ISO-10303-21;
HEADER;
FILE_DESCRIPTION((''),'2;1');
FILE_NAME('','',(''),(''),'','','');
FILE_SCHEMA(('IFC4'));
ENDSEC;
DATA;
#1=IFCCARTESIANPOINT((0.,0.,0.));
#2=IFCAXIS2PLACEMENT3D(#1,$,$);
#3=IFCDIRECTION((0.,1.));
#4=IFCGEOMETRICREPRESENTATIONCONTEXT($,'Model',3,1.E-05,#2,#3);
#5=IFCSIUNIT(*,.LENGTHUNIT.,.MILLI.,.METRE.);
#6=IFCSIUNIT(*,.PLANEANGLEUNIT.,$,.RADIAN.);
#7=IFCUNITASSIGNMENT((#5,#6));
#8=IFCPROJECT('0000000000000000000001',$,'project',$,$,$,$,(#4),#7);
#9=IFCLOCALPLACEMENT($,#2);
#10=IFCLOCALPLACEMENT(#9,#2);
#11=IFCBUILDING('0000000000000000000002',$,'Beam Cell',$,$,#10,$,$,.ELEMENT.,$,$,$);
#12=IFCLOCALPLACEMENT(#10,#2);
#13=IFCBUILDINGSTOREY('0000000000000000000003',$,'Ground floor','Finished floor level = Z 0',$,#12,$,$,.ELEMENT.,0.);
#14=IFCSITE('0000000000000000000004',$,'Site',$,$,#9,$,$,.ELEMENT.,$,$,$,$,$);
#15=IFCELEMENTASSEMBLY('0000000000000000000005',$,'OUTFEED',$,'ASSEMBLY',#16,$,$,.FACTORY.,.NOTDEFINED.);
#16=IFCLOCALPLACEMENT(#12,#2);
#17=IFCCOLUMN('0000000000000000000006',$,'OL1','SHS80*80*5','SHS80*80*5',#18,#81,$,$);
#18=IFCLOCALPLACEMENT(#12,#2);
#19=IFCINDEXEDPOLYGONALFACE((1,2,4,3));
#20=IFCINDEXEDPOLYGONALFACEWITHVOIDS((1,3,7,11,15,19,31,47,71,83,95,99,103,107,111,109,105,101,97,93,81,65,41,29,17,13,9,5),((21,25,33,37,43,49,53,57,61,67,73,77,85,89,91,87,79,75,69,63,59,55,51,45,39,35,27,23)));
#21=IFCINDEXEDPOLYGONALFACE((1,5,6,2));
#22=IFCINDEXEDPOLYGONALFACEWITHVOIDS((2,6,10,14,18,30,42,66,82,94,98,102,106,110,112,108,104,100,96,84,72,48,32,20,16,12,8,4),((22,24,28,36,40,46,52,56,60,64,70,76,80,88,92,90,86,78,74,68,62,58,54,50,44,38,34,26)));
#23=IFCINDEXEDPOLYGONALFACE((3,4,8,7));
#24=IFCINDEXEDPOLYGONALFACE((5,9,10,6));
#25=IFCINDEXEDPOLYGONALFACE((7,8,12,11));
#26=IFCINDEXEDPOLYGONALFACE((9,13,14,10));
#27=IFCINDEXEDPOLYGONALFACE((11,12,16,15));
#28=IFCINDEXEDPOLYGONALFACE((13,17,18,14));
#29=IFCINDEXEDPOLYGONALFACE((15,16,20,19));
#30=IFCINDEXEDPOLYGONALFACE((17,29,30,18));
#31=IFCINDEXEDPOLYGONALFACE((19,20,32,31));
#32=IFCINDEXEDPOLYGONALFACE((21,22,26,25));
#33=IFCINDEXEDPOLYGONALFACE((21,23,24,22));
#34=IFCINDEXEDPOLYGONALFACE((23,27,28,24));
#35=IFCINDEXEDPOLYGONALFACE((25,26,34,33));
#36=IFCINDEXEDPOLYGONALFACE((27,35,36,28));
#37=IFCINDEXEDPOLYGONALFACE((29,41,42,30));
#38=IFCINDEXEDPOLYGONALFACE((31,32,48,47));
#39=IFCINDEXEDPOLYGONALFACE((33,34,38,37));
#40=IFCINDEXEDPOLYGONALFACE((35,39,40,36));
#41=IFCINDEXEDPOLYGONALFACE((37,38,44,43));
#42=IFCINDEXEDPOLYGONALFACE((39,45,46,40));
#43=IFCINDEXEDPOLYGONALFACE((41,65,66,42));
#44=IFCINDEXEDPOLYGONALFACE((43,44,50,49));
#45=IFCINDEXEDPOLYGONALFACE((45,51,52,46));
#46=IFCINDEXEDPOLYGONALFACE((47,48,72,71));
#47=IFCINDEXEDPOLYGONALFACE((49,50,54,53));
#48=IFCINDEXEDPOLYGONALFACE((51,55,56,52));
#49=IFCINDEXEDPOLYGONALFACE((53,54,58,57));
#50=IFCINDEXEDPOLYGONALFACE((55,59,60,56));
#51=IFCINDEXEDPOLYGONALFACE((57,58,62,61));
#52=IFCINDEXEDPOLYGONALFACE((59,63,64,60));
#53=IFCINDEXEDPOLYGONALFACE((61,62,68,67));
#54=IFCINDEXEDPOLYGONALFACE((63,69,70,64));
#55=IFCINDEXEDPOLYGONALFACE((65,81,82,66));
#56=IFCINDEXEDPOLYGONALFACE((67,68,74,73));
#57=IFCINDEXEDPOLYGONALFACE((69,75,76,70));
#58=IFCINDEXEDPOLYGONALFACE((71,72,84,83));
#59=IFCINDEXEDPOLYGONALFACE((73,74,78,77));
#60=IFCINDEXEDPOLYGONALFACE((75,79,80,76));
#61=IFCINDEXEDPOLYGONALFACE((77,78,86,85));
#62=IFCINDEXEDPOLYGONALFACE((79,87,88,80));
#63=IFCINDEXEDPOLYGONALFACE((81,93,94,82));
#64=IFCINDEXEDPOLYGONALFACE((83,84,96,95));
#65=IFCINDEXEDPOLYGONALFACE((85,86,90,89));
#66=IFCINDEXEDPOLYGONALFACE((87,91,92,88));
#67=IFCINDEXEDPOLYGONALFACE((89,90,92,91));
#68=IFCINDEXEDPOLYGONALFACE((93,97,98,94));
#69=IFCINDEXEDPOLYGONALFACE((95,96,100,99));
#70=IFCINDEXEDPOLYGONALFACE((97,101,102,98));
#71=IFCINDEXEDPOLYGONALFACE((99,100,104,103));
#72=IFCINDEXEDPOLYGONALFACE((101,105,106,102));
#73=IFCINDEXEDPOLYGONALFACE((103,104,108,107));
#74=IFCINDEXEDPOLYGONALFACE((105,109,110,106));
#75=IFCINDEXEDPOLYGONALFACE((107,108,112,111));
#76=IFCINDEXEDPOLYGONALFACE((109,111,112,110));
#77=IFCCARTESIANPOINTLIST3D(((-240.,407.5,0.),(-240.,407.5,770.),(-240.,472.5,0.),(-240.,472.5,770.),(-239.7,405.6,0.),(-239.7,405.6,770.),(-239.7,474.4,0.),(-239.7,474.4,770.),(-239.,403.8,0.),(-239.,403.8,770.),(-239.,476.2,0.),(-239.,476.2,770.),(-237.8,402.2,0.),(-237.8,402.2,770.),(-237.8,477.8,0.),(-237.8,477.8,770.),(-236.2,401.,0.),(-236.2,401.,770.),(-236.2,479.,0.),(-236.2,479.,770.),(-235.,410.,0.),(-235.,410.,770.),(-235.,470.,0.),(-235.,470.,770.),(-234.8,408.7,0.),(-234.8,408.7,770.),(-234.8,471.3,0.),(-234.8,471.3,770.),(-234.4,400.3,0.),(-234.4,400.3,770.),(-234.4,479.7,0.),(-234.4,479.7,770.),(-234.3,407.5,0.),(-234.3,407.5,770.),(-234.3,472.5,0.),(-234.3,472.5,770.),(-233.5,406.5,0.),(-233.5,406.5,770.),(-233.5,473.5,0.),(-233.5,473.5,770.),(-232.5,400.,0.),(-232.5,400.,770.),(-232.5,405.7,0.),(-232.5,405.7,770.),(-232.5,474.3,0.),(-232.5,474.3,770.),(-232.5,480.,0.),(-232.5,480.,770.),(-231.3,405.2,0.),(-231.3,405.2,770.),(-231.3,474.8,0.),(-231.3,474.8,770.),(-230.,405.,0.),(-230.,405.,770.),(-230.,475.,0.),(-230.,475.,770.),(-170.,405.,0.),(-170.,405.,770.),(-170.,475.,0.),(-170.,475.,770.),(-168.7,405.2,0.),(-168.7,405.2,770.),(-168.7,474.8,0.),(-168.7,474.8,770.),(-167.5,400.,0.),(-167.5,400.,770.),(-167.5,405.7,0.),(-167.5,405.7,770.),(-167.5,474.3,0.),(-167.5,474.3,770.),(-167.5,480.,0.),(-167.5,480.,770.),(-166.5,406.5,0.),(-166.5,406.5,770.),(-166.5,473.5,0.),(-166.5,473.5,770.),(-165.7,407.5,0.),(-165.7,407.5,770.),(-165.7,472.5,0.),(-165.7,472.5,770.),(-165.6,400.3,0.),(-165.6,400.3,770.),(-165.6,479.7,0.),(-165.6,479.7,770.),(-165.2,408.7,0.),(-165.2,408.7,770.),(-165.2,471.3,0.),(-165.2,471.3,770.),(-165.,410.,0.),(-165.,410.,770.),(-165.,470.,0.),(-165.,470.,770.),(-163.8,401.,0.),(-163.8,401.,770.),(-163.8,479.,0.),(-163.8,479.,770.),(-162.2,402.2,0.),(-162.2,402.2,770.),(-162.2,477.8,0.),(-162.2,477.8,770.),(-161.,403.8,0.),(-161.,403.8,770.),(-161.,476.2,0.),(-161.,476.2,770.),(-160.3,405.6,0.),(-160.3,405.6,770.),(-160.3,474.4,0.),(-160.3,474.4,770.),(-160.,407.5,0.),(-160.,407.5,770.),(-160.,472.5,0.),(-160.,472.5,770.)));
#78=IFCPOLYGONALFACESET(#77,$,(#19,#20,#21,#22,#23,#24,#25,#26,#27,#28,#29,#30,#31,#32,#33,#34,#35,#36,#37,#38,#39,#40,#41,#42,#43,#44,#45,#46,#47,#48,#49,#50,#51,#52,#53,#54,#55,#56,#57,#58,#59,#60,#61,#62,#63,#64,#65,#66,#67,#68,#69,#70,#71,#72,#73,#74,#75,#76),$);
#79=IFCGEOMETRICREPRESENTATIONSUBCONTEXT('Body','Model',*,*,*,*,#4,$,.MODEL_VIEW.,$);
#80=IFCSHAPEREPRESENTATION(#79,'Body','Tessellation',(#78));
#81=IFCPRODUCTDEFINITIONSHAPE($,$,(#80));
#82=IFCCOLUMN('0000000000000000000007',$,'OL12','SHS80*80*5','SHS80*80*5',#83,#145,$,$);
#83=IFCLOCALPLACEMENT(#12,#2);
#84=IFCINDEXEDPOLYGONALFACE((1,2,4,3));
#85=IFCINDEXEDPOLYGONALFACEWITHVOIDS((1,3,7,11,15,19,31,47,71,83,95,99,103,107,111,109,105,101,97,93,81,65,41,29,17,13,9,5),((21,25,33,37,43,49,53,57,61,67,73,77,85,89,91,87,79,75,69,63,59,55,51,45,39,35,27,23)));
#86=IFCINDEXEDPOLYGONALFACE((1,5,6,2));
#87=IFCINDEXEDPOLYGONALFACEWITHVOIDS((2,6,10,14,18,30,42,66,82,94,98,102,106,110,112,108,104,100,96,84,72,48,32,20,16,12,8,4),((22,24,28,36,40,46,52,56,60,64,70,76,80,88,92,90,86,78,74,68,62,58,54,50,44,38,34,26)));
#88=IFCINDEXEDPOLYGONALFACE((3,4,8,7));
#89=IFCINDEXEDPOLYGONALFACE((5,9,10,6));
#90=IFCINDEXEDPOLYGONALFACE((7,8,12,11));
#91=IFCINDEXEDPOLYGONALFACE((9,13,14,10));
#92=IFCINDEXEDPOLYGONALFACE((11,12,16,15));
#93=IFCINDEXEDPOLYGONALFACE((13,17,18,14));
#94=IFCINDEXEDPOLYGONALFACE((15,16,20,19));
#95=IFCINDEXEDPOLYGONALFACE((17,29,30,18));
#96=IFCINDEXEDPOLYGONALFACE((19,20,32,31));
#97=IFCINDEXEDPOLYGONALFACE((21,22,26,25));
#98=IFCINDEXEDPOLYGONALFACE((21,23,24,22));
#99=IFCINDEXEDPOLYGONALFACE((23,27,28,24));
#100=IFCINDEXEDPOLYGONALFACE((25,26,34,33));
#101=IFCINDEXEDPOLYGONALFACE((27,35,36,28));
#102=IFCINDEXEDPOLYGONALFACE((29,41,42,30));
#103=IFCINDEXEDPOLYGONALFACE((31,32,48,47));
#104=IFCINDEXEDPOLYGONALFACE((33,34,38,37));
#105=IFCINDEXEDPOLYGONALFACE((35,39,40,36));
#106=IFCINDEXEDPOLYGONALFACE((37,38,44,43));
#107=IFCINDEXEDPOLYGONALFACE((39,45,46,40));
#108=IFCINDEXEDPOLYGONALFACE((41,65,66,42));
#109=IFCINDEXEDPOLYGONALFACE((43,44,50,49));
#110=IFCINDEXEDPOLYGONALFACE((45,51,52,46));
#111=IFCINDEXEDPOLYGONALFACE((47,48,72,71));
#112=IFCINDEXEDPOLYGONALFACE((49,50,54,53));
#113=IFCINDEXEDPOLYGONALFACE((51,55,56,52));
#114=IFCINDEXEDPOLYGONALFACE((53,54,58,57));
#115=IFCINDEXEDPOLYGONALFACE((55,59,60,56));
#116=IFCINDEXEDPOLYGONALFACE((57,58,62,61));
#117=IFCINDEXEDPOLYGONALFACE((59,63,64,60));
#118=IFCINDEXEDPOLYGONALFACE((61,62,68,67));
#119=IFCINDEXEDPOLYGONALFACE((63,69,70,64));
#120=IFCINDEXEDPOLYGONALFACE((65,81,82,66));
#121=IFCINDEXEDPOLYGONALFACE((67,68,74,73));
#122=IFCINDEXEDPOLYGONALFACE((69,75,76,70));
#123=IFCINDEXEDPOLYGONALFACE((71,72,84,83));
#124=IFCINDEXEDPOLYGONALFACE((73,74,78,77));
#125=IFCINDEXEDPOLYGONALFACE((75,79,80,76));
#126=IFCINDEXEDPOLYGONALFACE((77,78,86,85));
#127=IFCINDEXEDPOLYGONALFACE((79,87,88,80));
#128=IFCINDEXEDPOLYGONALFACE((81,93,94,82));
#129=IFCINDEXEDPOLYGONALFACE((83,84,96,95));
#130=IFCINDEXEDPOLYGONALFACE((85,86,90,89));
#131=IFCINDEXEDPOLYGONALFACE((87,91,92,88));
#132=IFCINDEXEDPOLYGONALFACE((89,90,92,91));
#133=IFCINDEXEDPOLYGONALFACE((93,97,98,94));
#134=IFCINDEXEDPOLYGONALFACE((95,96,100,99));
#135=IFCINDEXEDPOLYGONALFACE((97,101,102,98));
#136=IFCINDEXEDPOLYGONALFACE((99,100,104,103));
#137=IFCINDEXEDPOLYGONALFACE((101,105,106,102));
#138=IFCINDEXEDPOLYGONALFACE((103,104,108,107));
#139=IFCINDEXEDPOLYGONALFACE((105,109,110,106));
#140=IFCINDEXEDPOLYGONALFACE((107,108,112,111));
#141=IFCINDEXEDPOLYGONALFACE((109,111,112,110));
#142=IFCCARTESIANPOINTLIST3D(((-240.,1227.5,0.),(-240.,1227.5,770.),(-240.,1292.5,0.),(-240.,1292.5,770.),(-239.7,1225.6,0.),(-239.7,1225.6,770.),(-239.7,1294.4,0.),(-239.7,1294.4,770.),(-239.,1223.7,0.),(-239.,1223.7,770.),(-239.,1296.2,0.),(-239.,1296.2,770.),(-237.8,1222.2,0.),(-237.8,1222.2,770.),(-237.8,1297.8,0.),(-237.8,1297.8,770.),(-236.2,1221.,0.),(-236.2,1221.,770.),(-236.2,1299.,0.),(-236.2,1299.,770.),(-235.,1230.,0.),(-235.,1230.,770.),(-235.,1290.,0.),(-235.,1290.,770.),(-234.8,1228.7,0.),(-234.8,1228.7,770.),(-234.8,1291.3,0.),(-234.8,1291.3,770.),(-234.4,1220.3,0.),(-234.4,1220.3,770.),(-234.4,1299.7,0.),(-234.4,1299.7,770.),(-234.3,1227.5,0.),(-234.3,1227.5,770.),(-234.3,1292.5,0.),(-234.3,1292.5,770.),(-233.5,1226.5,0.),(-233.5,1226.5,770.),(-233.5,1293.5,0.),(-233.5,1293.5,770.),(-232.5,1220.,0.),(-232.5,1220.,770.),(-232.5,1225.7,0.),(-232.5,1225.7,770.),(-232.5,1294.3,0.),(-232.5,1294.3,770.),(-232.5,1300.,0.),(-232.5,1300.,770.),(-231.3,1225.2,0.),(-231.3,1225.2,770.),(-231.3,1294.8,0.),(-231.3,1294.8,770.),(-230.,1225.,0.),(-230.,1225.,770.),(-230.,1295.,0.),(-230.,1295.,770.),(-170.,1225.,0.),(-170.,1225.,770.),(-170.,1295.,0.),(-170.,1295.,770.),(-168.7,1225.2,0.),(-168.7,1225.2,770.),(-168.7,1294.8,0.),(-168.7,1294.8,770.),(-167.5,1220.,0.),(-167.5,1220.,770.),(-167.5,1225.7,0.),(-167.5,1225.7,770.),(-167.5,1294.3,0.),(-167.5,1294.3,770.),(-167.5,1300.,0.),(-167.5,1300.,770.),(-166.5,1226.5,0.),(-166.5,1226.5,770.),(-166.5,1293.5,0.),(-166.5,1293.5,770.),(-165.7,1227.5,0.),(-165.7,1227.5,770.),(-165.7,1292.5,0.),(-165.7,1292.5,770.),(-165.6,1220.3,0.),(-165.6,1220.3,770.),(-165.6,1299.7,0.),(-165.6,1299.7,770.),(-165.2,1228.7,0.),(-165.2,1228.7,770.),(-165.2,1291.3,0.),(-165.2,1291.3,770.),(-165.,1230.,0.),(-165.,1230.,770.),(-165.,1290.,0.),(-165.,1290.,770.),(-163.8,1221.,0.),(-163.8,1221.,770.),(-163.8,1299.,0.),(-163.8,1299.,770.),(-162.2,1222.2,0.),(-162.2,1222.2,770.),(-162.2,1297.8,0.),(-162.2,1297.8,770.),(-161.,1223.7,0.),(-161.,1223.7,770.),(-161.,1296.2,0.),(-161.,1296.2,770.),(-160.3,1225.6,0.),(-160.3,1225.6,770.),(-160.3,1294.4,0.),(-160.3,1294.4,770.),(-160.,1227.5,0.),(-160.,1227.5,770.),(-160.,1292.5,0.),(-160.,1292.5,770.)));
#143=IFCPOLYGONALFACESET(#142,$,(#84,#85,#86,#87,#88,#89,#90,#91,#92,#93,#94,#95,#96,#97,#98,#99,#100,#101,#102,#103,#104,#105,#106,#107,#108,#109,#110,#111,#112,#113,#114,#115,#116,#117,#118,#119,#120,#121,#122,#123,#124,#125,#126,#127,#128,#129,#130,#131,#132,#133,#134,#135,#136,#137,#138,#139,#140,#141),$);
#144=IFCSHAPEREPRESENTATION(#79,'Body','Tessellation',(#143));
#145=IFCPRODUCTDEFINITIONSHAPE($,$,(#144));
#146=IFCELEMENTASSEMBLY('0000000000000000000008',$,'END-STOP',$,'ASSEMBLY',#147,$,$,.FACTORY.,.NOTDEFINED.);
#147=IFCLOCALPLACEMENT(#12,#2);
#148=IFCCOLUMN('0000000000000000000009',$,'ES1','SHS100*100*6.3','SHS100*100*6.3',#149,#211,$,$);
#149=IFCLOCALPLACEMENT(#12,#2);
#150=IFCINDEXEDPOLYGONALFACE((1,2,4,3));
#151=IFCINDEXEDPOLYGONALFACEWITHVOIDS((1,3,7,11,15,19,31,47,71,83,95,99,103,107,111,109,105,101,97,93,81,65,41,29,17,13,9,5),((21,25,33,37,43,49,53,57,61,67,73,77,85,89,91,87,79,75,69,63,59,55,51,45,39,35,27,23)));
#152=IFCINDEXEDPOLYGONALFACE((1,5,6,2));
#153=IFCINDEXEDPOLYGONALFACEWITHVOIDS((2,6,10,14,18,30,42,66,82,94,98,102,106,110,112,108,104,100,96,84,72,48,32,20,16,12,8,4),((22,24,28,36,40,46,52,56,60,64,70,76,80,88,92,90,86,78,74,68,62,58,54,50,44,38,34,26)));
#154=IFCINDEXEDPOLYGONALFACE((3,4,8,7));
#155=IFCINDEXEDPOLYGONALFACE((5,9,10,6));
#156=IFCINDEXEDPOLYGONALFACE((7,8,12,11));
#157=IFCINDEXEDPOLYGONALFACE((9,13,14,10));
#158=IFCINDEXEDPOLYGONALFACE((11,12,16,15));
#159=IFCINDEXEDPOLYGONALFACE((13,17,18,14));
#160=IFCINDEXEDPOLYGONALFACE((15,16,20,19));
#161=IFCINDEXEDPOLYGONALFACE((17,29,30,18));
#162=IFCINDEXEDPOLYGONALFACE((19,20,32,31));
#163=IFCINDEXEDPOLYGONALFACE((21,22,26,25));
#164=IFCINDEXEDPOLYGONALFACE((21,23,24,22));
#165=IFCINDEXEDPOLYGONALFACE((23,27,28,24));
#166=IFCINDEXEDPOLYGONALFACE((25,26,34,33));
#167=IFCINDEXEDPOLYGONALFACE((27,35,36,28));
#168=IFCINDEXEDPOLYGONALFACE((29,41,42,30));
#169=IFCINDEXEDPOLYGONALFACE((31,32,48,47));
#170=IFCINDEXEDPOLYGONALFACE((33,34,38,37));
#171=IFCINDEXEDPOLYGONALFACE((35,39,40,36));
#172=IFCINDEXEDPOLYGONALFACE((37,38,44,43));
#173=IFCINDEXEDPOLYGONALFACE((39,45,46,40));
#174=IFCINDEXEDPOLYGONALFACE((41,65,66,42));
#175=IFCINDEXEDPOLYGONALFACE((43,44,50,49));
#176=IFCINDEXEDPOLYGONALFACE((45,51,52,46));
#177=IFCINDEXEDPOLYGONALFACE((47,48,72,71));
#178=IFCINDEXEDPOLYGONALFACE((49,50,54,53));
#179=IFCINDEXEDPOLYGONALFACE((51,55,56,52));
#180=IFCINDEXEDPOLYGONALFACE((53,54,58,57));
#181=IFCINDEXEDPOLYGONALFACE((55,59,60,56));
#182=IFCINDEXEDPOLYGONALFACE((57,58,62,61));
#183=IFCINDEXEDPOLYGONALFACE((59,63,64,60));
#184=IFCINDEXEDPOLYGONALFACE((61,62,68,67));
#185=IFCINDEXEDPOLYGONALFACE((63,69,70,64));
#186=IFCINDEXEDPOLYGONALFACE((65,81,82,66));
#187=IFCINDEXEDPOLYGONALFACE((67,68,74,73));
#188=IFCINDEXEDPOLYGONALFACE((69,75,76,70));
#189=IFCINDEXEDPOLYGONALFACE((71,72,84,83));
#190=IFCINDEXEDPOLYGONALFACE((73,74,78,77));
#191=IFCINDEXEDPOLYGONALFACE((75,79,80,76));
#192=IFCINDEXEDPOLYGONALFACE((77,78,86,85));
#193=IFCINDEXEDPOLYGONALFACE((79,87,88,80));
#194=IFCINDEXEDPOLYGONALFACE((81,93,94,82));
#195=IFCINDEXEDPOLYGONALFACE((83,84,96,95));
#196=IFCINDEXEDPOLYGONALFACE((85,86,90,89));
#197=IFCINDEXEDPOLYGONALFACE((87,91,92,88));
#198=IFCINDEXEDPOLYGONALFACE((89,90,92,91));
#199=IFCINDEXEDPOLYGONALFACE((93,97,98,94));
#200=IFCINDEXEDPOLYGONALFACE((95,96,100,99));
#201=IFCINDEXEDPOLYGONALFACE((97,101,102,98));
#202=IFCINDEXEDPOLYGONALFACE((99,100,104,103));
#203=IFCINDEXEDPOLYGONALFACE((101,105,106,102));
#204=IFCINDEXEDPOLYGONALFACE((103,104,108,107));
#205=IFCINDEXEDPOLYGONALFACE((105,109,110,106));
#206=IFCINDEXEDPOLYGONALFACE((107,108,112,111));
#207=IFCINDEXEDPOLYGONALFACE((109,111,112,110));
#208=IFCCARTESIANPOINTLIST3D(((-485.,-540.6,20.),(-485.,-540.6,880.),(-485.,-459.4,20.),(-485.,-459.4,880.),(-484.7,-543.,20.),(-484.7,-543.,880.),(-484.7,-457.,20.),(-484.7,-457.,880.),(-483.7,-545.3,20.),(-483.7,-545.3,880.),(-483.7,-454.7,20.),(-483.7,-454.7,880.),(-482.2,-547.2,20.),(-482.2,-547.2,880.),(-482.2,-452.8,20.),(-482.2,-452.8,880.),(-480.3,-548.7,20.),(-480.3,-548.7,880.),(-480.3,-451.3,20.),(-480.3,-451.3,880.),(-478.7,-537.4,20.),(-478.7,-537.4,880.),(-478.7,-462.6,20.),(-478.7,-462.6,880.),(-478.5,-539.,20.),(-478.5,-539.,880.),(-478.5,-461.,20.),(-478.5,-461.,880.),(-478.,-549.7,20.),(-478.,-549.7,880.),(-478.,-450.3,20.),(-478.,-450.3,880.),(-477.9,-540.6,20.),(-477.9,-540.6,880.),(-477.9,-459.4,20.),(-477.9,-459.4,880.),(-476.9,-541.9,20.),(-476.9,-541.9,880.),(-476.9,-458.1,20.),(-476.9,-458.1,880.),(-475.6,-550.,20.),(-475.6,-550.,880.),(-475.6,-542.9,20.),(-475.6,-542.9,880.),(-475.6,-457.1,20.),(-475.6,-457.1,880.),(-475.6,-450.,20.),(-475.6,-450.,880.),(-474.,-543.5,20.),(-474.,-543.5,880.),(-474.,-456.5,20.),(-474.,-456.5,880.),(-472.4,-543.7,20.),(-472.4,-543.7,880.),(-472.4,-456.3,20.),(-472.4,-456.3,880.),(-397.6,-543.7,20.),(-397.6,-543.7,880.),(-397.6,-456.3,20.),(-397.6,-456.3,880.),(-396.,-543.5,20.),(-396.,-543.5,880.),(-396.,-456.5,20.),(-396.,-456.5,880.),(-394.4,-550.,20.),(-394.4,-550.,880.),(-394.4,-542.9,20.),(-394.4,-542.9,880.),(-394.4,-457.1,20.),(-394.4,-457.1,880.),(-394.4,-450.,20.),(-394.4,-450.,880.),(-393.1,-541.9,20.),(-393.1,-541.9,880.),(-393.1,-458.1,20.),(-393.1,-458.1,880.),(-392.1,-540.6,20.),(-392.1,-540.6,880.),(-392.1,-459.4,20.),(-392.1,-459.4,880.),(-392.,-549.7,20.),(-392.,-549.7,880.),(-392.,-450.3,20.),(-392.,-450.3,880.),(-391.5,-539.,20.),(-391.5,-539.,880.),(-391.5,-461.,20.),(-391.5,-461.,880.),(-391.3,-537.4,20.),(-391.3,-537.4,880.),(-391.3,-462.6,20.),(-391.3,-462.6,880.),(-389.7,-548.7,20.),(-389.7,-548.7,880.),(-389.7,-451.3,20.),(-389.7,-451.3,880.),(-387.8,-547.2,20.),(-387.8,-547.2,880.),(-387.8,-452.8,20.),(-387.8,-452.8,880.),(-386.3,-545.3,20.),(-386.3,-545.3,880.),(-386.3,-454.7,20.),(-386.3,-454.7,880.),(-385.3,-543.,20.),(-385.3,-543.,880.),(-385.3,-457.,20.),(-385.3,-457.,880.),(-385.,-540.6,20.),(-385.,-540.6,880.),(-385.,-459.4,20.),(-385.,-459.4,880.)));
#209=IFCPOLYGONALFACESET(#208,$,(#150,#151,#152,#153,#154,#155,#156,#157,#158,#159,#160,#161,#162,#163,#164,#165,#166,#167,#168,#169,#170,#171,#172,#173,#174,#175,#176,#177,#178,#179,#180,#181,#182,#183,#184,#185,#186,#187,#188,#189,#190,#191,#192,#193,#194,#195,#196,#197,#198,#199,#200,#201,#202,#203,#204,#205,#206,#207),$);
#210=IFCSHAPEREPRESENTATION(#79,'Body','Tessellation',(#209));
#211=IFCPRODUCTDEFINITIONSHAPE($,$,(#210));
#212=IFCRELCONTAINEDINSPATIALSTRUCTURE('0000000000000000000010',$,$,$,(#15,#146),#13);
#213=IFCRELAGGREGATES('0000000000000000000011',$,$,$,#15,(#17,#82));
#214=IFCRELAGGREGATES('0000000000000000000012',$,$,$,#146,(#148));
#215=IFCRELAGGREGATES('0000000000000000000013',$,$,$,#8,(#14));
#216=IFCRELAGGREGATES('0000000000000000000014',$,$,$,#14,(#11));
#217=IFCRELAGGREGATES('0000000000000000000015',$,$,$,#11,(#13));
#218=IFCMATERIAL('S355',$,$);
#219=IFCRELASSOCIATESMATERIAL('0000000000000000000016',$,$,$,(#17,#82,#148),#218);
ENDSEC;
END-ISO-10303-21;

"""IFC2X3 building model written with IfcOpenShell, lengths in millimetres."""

from ifc_helpers import new_model, si_unit, direction, frame, origin, origin_2d, place, context, subcontext, project, spatial, hollow_rectangle, extrude, material, element, aggregate, save


model = new_model("IFC2X3")

# Units and contexts
model_context = context("Model", 3, precision=1e-05, world=origin(), true_north=direction((0.0, 1.0)))
body_context = subcontext(model_context, "Body", "Model", "MODEL_VIEW")
ifc_project = project(units=[si_unit("LENGTHUNIT", "METRE", prefix="MILLI"), si_unit("PLANEANGLEUNIT", "RADIAN")], contexts=[model_context])

# Site, building, storey
site_placement = place(None, origin())
site = spatial("IfcSite", under=ifc_project, at=site_placement, Name="Site", CompositionType="ELEMENT")
building_placement = place(site_placement, origin())
building = spatial("IfcBuilding", under=site, at=building_placement, Name="Beam Cell", CompositionType="ELEMENT")
storey_placement = place(building_placement, origin())
storey = spatial("IfcBuildingStorey", under=building, at=storey_placement, Name="Ground floor", Description="Finished floor level = Z 0", CompositionType="ELEMENT", Elevation=0.0)

# Shared definitions
ifc_material = material(Name="S355")

# Element assembly, columns
assembly_1_placement = place(storey_placement, origin())
assembly_1 = element("IfcElementAssembly", 1, at=assembly_1_placement, inside=storey, Name="OUTFEED", ObjectType="ASSEMBLY", AssemblyPlace="FACTORY", PredefinedType="NOTDEFINED")
column_1_placement = place(storey_placement, frame((-200.0, 440.0, 0.0), z_axis=(0.0, 0.0, 1.0), x_axis=(1.0, 0.0, 0.0)))
column_1 = element("IfcColumn", 2, at=column_1_placement, material=ifc_material, Name="OL1", Description="SHS80*80*5", ObjectType="SHS80*80*5", context=body_context, shape_type="SweptSolid", body=[
    extrude(hollow_rectangle(XDim=80.0, YDim=80.0, WallThickness=5.0, InnerFilletRadius=5.0, OuterFilletRadius=7.5, at=origin_2d()), origin(), (0.0, 0.0, 1.0), 770.0),
])
column_2_placement = place(storey_placement, frame((-200.0, 1260.0, 0.0), z_axis=(0.0, 0.0, 1.0), x_axis=(1.0, 0.0, 0.0)))
column_2 = element("IfcColumn", 3, at=column_2_placement, material=ifc_material, Name="OL12", Description="SHS80*80*5", ObjectType="SHS80*80*5", context=body_context, shape_type="SweptSolid", body=[
    extrude(hollow_rectangle(XDim=80.0, YDim=80.0, WallThickness=5.0, InnerFilletRadius=5.0, OuterFilletRadius=7.5, at=origin_2d()), origin(), (0.0, 0.0, 1.0), 770.0),
])

# Element assembly, column
assembly_2_placement = place(storey_placement, origin())
assembly_2 = element("IfcElementAssembly", 4, at=assembly_2_placement, inside=storey, Name="END-STOP", ObjectType="ASSEMBLY", AssemblyPlace="FACTORY", PredefinedType="NOTDEFINED")
column_3_placement = place(storey_placement, frame((-435.0, -500.0, 20.0), z_axis=(0.0, 0.0, 1.0), x_axis=(1.0, 0.0, 0.0)))
column_3 = element("IfcColumn", 5, at=column_3_placement, material=ifc_material, Name="ES1", Description="SHS100*100*6.3", ObjectType="SHS100*100*6.3", context=body_context, shape_type="SweptSolid", body=[
    extrude(hollow_rectangle(XDim=100.0, YDim=100.0, WallThickness=6.3, InnerFilletRadius=6.3, OuterFilletRadius=9.4, at=origin_2d()), origin(), (0.0, 0.0, 1.0), 860.0),
])

aggregate(assembly_1, [column_1, column_2])

aggregate(assembly_2, [column_3])

save(model, "model.ifc")
